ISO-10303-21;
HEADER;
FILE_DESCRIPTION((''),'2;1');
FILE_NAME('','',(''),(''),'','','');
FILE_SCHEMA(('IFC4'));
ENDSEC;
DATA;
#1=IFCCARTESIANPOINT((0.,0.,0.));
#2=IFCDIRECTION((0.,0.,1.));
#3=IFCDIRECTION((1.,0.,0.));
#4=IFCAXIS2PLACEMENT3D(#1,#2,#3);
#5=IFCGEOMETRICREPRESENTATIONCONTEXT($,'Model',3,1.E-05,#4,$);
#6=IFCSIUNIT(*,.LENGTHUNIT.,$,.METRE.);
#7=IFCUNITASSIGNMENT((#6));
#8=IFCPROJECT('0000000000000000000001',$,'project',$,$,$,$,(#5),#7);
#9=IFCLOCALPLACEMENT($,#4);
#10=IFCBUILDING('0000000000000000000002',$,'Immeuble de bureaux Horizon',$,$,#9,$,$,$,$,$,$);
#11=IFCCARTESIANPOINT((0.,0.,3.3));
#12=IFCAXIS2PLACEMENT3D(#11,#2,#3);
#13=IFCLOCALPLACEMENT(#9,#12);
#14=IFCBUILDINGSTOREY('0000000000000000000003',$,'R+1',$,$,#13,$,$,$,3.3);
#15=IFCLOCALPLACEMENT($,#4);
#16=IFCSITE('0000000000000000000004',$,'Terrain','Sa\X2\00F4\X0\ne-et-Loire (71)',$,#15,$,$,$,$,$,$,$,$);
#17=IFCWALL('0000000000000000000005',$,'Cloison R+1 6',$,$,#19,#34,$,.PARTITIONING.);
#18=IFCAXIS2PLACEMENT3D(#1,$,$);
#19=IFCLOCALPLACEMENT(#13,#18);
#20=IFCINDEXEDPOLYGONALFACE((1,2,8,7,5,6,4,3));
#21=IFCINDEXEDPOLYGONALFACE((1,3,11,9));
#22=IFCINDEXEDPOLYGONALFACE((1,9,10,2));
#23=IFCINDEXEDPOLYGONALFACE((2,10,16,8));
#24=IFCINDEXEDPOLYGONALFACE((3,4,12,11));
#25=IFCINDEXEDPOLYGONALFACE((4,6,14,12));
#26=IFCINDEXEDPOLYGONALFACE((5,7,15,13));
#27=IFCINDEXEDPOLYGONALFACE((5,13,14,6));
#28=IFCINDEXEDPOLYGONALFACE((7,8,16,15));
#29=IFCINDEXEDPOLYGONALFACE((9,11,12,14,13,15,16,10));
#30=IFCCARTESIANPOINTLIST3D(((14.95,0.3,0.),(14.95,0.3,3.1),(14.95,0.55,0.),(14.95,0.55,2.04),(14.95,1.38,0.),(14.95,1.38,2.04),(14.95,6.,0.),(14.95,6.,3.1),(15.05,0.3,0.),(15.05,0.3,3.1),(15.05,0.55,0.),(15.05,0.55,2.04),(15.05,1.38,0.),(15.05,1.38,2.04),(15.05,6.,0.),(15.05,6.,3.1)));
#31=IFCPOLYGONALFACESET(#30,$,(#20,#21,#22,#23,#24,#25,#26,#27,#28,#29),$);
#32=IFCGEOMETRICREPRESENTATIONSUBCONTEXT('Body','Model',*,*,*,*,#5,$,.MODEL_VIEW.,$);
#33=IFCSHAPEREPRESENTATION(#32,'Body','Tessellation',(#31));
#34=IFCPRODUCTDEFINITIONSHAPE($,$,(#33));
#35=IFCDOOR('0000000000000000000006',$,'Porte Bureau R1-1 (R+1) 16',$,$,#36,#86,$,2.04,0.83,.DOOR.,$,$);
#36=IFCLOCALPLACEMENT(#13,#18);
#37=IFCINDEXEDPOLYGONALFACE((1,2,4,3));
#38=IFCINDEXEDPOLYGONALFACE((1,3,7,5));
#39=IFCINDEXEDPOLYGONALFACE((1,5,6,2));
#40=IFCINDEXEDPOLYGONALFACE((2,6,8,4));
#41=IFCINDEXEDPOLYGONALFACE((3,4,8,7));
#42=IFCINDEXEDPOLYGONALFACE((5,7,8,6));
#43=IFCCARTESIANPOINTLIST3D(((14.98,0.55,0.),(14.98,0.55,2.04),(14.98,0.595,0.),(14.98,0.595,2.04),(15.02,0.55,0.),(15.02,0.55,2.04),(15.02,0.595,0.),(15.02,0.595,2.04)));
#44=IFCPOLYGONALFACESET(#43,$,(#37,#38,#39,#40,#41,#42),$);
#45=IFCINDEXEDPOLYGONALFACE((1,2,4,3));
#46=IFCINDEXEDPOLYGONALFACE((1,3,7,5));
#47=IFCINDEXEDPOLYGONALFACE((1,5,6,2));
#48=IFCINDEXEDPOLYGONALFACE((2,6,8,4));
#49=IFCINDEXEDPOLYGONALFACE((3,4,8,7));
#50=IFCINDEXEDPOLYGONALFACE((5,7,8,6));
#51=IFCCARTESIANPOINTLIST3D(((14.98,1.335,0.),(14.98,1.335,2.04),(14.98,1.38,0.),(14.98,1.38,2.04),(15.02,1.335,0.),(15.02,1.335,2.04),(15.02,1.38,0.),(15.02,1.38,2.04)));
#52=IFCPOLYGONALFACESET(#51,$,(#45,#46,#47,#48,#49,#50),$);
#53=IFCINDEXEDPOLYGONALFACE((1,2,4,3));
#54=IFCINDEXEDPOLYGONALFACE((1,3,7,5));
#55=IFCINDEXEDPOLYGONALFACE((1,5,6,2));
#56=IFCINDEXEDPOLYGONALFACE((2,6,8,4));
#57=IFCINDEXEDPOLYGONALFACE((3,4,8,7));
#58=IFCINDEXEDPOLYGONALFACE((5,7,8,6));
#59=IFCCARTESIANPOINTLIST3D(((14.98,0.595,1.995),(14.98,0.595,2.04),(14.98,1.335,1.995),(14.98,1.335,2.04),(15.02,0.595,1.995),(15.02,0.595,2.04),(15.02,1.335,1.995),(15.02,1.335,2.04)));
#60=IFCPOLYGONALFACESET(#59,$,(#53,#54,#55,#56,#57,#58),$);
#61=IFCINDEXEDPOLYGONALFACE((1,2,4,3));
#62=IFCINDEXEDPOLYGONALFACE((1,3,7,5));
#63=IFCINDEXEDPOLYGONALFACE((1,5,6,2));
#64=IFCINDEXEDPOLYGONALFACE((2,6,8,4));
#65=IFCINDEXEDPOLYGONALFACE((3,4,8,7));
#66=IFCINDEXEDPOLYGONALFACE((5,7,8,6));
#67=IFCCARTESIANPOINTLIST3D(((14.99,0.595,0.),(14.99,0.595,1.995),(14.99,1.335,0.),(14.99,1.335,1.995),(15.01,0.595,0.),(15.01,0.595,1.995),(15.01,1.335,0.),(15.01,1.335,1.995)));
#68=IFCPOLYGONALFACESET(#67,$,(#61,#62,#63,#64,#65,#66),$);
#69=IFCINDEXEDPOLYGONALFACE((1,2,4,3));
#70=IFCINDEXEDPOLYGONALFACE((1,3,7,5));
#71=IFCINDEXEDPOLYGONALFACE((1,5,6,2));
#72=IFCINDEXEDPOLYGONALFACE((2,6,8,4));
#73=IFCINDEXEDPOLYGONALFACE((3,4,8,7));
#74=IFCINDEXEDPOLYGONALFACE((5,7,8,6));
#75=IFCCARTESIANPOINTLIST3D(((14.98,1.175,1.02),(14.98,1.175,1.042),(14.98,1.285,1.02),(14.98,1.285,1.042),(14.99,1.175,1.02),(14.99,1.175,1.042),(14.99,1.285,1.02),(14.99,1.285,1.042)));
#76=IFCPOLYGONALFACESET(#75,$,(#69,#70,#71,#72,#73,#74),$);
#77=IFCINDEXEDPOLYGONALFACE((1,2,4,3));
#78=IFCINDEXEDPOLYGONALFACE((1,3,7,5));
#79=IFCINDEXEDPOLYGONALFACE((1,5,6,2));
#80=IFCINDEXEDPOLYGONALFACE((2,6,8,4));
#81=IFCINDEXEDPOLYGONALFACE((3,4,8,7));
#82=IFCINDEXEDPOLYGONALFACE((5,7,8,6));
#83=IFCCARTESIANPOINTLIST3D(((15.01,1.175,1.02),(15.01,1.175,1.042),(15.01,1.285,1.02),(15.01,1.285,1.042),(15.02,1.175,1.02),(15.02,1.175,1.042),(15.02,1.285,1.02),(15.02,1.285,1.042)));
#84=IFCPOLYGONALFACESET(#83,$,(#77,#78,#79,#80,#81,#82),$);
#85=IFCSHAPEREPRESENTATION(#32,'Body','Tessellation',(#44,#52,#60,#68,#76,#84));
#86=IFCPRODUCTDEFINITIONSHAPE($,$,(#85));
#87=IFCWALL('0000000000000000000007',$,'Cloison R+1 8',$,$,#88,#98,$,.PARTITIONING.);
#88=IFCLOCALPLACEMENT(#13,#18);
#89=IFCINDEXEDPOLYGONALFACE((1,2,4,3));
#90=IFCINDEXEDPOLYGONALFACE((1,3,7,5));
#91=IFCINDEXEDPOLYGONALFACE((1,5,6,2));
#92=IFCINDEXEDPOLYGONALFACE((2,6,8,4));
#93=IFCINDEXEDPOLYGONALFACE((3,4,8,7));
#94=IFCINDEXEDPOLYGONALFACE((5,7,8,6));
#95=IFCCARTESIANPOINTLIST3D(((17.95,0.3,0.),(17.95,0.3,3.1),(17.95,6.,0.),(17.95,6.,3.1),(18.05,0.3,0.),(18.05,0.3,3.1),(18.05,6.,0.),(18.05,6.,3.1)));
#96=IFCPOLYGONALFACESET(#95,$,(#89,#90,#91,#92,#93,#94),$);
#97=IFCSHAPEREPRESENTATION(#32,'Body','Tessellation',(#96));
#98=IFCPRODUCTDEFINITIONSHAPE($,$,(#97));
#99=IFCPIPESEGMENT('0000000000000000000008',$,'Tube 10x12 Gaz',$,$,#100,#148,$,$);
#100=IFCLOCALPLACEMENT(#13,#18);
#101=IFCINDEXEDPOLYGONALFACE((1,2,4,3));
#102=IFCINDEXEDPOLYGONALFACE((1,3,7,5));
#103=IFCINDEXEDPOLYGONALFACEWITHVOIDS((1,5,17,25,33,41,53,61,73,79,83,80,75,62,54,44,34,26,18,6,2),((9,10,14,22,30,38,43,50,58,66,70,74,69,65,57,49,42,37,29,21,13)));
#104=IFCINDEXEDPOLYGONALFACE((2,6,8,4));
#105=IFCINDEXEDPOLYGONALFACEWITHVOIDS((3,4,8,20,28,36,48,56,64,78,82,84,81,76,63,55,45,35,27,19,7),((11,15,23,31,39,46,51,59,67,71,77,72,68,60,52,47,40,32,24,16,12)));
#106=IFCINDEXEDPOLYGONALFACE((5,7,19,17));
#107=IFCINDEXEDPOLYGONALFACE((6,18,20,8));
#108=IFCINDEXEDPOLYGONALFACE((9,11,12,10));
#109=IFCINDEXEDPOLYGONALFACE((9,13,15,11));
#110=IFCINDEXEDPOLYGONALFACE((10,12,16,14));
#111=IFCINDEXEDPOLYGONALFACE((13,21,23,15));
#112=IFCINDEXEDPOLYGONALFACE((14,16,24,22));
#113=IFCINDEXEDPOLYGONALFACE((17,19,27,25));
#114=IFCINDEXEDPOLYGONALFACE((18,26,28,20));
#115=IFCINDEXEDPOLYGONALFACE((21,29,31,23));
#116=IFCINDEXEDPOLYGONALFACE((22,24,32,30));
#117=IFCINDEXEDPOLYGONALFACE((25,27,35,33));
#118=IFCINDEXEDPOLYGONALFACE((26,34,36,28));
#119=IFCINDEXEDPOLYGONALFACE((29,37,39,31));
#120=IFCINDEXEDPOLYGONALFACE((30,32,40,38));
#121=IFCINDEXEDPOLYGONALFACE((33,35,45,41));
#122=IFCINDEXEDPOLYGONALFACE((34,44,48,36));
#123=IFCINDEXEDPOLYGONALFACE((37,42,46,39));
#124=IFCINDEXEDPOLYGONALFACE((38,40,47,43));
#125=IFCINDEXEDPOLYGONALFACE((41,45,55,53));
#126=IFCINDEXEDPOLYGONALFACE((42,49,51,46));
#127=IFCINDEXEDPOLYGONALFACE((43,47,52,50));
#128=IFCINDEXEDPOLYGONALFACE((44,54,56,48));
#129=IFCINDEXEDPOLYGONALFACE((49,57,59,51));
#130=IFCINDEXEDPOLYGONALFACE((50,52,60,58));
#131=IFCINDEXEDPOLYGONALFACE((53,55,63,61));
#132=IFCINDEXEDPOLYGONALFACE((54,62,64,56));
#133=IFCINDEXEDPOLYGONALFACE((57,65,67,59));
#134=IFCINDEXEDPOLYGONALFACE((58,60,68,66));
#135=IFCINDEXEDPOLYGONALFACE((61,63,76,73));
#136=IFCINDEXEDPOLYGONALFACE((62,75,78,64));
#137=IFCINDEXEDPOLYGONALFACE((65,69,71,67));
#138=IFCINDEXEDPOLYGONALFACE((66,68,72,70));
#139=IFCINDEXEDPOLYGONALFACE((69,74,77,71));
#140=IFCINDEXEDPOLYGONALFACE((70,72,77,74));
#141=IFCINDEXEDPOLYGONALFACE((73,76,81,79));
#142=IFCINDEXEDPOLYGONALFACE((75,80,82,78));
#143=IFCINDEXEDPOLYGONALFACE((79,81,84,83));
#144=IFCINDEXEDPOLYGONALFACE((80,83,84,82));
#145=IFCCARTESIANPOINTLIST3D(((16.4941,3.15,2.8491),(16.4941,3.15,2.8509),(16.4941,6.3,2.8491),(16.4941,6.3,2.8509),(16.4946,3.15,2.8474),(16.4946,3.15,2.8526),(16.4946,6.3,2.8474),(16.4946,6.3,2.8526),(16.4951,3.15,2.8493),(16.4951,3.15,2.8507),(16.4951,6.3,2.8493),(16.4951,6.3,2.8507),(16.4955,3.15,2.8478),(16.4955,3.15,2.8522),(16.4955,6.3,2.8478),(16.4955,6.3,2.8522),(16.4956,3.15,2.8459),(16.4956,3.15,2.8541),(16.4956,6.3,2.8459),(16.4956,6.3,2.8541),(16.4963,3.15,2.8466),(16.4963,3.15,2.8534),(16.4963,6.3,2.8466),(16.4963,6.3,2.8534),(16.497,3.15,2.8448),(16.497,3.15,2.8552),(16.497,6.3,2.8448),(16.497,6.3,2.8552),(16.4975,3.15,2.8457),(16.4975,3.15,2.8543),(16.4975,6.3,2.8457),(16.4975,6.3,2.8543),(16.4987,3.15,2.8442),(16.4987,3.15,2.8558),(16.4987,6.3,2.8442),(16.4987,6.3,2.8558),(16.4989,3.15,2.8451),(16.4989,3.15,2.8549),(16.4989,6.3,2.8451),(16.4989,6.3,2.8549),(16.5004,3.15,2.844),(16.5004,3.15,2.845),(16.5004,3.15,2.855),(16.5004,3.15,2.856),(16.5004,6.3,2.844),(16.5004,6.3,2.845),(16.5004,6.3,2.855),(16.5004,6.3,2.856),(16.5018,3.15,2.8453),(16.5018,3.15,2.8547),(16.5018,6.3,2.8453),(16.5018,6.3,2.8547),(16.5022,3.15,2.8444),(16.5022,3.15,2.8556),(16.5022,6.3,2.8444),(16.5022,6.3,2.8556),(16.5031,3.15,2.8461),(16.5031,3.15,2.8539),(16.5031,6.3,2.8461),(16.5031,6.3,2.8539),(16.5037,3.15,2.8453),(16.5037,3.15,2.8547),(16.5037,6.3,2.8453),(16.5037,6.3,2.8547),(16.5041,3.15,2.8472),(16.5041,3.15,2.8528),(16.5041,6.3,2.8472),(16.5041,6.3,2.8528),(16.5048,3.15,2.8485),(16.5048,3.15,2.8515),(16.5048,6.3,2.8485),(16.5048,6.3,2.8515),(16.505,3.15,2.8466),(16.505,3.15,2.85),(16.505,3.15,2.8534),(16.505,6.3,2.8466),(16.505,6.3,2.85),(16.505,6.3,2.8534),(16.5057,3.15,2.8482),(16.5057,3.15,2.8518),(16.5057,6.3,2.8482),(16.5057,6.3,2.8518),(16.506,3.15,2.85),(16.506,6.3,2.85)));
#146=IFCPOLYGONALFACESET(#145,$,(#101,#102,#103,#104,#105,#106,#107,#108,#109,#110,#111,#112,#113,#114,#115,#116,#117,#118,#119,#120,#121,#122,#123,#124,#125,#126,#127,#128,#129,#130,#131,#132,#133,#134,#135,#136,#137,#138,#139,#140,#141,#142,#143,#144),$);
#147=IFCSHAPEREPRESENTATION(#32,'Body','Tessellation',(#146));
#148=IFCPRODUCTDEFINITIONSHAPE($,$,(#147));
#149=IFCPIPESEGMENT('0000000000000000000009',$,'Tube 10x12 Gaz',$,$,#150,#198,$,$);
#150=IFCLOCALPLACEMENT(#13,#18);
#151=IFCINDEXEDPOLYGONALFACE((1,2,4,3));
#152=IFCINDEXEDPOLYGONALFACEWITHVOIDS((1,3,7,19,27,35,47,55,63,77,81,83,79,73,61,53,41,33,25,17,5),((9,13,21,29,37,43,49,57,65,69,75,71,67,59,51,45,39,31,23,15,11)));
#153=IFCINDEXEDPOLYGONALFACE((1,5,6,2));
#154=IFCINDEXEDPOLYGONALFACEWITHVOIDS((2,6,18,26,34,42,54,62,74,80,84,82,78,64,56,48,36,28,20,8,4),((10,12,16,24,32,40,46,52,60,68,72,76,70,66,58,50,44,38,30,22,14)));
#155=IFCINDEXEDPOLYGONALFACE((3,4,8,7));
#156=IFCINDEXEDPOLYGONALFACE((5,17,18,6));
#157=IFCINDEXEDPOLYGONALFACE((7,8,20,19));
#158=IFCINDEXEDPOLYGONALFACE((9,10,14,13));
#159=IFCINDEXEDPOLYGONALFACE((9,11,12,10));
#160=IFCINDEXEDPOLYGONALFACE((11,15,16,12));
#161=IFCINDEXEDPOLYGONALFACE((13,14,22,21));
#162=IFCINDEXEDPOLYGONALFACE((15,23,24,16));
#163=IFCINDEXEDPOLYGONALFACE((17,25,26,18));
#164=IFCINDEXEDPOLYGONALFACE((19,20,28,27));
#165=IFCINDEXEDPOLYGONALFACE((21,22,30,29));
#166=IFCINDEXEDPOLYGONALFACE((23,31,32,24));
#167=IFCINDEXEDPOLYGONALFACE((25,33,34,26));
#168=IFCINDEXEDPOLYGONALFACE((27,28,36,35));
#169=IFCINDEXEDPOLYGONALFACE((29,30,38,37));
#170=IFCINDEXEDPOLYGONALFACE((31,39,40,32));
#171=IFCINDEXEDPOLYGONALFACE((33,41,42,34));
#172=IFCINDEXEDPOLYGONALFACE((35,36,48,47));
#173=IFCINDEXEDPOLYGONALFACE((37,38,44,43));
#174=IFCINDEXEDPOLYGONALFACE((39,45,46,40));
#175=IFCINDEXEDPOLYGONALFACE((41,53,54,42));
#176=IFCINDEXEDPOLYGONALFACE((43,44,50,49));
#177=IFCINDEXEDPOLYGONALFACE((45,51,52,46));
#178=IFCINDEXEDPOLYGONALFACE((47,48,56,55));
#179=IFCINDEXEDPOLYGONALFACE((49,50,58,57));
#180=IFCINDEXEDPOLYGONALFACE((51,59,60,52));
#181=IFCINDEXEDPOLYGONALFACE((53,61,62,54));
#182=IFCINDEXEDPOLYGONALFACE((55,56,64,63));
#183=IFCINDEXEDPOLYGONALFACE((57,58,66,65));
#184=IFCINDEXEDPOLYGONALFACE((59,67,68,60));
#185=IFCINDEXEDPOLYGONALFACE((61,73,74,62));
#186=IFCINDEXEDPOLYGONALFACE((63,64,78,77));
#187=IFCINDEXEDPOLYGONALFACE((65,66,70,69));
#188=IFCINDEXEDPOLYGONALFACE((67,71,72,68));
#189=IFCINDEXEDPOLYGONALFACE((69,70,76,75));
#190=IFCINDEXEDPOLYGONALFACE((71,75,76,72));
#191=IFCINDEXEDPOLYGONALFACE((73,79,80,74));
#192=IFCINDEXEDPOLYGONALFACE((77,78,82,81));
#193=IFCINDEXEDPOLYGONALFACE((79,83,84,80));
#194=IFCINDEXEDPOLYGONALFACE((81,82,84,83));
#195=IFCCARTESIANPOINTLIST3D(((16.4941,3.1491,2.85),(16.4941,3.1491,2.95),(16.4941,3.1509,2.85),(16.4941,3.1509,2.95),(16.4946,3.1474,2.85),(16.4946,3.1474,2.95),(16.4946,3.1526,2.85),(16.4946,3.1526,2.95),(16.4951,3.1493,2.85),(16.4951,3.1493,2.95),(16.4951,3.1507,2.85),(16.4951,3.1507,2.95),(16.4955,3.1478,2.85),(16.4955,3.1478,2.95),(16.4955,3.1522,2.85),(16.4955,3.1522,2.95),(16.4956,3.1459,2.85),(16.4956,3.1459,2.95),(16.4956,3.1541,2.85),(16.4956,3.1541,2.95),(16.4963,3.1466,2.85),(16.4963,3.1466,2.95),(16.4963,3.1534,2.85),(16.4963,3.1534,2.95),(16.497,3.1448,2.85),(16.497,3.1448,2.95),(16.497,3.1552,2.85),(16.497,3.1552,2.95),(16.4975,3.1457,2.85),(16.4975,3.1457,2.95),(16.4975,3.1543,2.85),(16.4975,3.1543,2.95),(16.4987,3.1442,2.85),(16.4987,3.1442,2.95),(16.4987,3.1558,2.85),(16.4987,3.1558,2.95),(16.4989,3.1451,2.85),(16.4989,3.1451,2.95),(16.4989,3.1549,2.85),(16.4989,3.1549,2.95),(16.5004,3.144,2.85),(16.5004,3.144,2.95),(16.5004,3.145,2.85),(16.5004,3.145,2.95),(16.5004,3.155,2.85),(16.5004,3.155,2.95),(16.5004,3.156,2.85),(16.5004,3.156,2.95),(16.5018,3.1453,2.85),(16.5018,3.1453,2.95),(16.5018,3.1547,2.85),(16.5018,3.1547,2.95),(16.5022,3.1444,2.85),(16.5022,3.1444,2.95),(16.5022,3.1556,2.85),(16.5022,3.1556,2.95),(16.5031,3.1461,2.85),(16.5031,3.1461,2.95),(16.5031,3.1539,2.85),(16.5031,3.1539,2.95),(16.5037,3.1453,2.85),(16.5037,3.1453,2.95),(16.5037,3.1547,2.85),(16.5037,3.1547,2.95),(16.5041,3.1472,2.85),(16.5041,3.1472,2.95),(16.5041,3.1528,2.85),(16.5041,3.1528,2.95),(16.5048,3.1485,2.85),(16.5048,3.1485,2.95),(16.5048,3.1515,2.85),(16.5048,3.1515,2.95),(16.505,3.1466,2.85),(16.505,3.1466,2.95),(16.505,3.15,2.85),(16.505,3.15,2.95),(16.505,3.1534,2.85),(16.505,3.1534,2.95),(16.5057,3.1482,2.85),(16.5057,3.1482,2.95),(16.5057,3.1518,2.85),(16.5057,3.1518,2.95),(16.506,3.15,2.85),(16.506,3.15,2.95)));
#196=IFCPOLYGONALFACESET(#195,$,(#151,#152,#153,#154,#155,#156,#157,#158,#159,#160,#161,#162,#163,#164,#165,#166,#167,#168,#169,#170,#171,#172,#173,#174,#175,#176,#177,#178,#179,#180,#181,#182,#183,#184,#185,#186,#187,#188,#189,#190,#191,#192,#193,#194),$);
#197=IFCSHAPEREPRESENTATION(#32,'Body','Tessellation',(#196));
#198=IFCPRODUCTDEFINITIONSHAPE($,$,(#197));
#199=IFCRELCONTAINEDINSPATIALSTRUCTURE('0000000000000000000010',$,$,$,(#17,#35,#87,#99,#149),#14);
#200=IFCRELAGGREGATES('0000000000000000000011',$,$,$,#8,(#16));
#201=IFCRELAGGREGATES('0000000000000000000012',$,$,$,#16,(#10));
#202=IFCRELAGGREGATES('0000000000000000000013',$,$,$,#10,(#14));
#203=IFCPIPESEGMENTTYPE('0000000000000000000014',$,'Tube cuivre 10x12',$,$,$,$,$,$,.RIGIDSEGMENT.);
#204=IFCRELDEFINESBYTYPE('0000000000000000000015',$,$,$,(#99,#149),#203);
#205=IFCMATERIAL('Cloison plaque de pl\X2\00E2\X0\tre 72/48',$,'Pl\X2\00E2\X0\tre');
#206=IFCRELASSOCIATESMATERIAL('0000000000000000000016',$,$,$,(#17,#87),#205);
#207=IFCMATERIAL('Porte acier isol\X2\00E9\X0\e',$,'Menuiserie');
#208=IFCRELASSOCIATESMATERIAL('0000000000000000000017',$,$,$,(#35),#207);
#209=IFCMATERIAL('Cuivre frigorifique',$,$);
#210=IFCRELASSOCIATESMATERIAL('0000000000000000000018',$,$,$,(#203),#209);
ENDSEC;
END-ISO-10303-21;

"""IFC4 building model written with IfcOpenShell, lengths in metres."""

from ifc_helpers import new_model, si_unit, frame, frame_2d, origin_with_axes, place, context, subcontext, project, spatial, rectangle, hollow_circle, extrude, material, type_object, element, fill, save


model = new_model("IFC4")

# Units and contexts
model_context = context("Model", 3, precision=1e-05, world=origin_with_axes())
body_context = subcontext(model_context, "Body", "Model", "MODEL_VIEW")
ifc_project = project(units=[si_unit("LENGTHUNIT", "METRE")], contexts=[model_context])

# Site, building, storey
site_placement = place(None, origin_with_axes())
site = spatial("IfcSite", under=ifc_project, at=site_placement, Name="Terrain", Description="Saône-et-Loire (71)")
building_placement = place(None, origin_with_axes())
building = spatial("IfcBuilding", under=site, at=building_placement, Name="Immeuble de bureaux Horizon")
storey_placement = place(building_placement, frame((0.0, 0.0, 3.3), z_axis=(0.0, 0.0, 1.0), x_axis=(1.0, 0.0, 0.0)))
storey = spatial("IfcBuildingStorey", under=building, at=storey_placement, Name="R+1", Elevation=3.3)

# Wall, opening, door
ifc_material_1 = material(Name="Cloison plaque de plâtre 72/48", Category="Plâtre")
wall_1_placement = place(storey_placement, frame((14.95, 0.3, 0.0), z_axis=(0.0, 0.0, 1.0), x_axis=(1.0, 0.0, 0.0)))
wall_1 = element("IfcWall", 1, at=wall_1_placement, inside=storey, material=ifc_material_1, Name="Cloison R+1 6", PredefinedType="PARTITIONING", context=body_context, shape_type="SweptSolid", body=[
    extrude(rectangle(XDim=0.1, YDim=5.7, at=frame_2d((0.05, 2.85))), origin_with_axes(), (0.0, 0.0, 1.0), 3.1),
])
opening_placement = place(storey_placement, frame((14.9, 0.55, 0.0), z_axis=(0.0, 0.0, 1.0), x_axis=(1.0, 0.0, 0.0)))
opening = element("IfcOpeningElement", 2, at=opening_placement, cuts=wall_1, context=body_context, shape_type="SweptSolid", body=[
    extrude(rectangle(XDim=0.2, YDim=0.83, at=frame_2d((0.1, 0.415))), origin_with_axes(), (0.0, 0.0, 1.0), 2.04),
])
ifc_material_2 = material(Name="Porte acier isolée", Category="Menuiserie")
door_placement = place(storey_placement, frame((14.98, 0.55, 0.0), z_axis=(0.0, 0.0, 1.0), x_axis=(1.0, 0.0, 0.0)))
door = element("IfcDoor", 3, at=door_placement, inside=storey, material=ifc_material_2, Name="Porte Bureau R1-1 (R+1) 16", OverallHeight=2.04, OverallWidth=0.83, PredefinedType="DOOR", context=body_context, shape_type="SweptSolid", body=[
    extrude(rectangle(XDim=0.04, YDim=0.045, at=frame_2d((0.02, 0.0225))), origin_with_axes(), (0.0, 0.0, 1.0), 2.04),
    extrude(rectangle(XDim=0.04, YDim=0.045, at=frame_2d((0.02, 0.0225))), frame((0.0, 0.785, 0.0), z_axis=(0.0, 0.0, 1.0), x_axis=(1.0, 0.0, 0.0)), (0.0, 0.0, 1.0), 2.04),
    extrude(rectangle(XDim=0.04, YDim=0.74, at=frame_2d((0.02, 0.37))), frame((0.0, 0.045, 1.995), z_axis=(0.0, 0.0, 1.0), x_axis=(1.0, 0.0, 0.0)), (0.0, 0.0, 1.0), 0.045),
    extrude(rectangle(XDim=0.02, YDim=0.74, at=frame_2d((0.01, 0.37))), frame((0.01, 0.045, 0.0), z_axis=(0.0, 0.0, 1.0), x_axis=(1.0, 0.0, 0.0)), (0.0, 0.0, 1.0), 1.995),
    extrude(rectangle(XDim=0.01, YDim=0.11, at=frame_2d((0.005, 0.055))), frame((0.0, 0.625, 1.02), z_axis=(0.0, 0.0, 1.0), x_axis=(1.0, 0.0, 0.0)), (0.0, 0.0, 1.0), 0.022),
    extrude(rectangle(XDim=0.01, YDim=0.11, at=frame_2d((0.005, 0.055))), frame((0.03, 0.625, 1.02), z_axis=(0.0, 0.0, 1.0), x_axis=(1.0, 0.0, 0.0)), (0.0, 0.0, 1.0), 0.022),
])
fill(opening, door)

# Wall
wall_2_placement = place(storey_placement, frame((17.95, 0.3, 0.0), z_axis=(0.0, 0.0, 1.0), x_axis=(1.0, 0.0, 0.0)))
element("IfcWall", 4, at=wall_2_placement, inside=storey, material=ifc_material_1, Name="Cloison R+1 8", PredefinedType="PARTITIONING", context=body_context, shape_type="SweptSolid", body=[
    extrude(rectangle(XDim=0.1, YDim=5.7, at=frame_2d((0.05, 2.85))), origin_with_axes(), (0.0, 0.0, 1.0), 3.1),
])

# Pipe segments
ifc_material_3 = material(Name="Cuivre frigorifique")
pipe_segment_type_1 = type_object("IfcPipeSegmentType", Name="Tube cuivre 10x12", PredefinedType="RIGIDSEGMENT", material=ifc_material_3)
pipe_segment_1_placement = place(storey_placement, frame((16.5, 6.3, 2.85), z_axis=(0.0, -1.0, 0.0), x_axis=(1.0, 0.0, 0.0)))
element("IfcPipeSegment", 5, at=pipe_segment_1_placement, inside=storey, type_object=pipe_segment_type_1, Name="Tube 10x12 Gaz", context=body_context, shape_type="SweptSolid", body=[
    extrude(hollow_circle(Radius=0.006, WallThickness=0.001), origin_with_axes(), (0.0, 0.0, 1.0), 3.15),
])
pipe_segment_2_placement = place(storey_placement, frame((16.5, 3.15, 2.85), z_axis=(0.0, 0.0, 1.0), x_axis=(1.0, 0.0, 0.0)))
element("IfcPipeSegment", 6, at=pipe_segment_2_placement, inside=storey, type_object=pipe_segment_type_1, Name="Tube 10x12 Gaz", context=body_context, shape_type="SweptSolid", body=[
    extrude(hollow_circle(Radius=0.006, WallThickness=0.001), origin_with_axes(), (0.0, 0.0, 1.0), 0.1),
])

save(model, "model.ifc")
